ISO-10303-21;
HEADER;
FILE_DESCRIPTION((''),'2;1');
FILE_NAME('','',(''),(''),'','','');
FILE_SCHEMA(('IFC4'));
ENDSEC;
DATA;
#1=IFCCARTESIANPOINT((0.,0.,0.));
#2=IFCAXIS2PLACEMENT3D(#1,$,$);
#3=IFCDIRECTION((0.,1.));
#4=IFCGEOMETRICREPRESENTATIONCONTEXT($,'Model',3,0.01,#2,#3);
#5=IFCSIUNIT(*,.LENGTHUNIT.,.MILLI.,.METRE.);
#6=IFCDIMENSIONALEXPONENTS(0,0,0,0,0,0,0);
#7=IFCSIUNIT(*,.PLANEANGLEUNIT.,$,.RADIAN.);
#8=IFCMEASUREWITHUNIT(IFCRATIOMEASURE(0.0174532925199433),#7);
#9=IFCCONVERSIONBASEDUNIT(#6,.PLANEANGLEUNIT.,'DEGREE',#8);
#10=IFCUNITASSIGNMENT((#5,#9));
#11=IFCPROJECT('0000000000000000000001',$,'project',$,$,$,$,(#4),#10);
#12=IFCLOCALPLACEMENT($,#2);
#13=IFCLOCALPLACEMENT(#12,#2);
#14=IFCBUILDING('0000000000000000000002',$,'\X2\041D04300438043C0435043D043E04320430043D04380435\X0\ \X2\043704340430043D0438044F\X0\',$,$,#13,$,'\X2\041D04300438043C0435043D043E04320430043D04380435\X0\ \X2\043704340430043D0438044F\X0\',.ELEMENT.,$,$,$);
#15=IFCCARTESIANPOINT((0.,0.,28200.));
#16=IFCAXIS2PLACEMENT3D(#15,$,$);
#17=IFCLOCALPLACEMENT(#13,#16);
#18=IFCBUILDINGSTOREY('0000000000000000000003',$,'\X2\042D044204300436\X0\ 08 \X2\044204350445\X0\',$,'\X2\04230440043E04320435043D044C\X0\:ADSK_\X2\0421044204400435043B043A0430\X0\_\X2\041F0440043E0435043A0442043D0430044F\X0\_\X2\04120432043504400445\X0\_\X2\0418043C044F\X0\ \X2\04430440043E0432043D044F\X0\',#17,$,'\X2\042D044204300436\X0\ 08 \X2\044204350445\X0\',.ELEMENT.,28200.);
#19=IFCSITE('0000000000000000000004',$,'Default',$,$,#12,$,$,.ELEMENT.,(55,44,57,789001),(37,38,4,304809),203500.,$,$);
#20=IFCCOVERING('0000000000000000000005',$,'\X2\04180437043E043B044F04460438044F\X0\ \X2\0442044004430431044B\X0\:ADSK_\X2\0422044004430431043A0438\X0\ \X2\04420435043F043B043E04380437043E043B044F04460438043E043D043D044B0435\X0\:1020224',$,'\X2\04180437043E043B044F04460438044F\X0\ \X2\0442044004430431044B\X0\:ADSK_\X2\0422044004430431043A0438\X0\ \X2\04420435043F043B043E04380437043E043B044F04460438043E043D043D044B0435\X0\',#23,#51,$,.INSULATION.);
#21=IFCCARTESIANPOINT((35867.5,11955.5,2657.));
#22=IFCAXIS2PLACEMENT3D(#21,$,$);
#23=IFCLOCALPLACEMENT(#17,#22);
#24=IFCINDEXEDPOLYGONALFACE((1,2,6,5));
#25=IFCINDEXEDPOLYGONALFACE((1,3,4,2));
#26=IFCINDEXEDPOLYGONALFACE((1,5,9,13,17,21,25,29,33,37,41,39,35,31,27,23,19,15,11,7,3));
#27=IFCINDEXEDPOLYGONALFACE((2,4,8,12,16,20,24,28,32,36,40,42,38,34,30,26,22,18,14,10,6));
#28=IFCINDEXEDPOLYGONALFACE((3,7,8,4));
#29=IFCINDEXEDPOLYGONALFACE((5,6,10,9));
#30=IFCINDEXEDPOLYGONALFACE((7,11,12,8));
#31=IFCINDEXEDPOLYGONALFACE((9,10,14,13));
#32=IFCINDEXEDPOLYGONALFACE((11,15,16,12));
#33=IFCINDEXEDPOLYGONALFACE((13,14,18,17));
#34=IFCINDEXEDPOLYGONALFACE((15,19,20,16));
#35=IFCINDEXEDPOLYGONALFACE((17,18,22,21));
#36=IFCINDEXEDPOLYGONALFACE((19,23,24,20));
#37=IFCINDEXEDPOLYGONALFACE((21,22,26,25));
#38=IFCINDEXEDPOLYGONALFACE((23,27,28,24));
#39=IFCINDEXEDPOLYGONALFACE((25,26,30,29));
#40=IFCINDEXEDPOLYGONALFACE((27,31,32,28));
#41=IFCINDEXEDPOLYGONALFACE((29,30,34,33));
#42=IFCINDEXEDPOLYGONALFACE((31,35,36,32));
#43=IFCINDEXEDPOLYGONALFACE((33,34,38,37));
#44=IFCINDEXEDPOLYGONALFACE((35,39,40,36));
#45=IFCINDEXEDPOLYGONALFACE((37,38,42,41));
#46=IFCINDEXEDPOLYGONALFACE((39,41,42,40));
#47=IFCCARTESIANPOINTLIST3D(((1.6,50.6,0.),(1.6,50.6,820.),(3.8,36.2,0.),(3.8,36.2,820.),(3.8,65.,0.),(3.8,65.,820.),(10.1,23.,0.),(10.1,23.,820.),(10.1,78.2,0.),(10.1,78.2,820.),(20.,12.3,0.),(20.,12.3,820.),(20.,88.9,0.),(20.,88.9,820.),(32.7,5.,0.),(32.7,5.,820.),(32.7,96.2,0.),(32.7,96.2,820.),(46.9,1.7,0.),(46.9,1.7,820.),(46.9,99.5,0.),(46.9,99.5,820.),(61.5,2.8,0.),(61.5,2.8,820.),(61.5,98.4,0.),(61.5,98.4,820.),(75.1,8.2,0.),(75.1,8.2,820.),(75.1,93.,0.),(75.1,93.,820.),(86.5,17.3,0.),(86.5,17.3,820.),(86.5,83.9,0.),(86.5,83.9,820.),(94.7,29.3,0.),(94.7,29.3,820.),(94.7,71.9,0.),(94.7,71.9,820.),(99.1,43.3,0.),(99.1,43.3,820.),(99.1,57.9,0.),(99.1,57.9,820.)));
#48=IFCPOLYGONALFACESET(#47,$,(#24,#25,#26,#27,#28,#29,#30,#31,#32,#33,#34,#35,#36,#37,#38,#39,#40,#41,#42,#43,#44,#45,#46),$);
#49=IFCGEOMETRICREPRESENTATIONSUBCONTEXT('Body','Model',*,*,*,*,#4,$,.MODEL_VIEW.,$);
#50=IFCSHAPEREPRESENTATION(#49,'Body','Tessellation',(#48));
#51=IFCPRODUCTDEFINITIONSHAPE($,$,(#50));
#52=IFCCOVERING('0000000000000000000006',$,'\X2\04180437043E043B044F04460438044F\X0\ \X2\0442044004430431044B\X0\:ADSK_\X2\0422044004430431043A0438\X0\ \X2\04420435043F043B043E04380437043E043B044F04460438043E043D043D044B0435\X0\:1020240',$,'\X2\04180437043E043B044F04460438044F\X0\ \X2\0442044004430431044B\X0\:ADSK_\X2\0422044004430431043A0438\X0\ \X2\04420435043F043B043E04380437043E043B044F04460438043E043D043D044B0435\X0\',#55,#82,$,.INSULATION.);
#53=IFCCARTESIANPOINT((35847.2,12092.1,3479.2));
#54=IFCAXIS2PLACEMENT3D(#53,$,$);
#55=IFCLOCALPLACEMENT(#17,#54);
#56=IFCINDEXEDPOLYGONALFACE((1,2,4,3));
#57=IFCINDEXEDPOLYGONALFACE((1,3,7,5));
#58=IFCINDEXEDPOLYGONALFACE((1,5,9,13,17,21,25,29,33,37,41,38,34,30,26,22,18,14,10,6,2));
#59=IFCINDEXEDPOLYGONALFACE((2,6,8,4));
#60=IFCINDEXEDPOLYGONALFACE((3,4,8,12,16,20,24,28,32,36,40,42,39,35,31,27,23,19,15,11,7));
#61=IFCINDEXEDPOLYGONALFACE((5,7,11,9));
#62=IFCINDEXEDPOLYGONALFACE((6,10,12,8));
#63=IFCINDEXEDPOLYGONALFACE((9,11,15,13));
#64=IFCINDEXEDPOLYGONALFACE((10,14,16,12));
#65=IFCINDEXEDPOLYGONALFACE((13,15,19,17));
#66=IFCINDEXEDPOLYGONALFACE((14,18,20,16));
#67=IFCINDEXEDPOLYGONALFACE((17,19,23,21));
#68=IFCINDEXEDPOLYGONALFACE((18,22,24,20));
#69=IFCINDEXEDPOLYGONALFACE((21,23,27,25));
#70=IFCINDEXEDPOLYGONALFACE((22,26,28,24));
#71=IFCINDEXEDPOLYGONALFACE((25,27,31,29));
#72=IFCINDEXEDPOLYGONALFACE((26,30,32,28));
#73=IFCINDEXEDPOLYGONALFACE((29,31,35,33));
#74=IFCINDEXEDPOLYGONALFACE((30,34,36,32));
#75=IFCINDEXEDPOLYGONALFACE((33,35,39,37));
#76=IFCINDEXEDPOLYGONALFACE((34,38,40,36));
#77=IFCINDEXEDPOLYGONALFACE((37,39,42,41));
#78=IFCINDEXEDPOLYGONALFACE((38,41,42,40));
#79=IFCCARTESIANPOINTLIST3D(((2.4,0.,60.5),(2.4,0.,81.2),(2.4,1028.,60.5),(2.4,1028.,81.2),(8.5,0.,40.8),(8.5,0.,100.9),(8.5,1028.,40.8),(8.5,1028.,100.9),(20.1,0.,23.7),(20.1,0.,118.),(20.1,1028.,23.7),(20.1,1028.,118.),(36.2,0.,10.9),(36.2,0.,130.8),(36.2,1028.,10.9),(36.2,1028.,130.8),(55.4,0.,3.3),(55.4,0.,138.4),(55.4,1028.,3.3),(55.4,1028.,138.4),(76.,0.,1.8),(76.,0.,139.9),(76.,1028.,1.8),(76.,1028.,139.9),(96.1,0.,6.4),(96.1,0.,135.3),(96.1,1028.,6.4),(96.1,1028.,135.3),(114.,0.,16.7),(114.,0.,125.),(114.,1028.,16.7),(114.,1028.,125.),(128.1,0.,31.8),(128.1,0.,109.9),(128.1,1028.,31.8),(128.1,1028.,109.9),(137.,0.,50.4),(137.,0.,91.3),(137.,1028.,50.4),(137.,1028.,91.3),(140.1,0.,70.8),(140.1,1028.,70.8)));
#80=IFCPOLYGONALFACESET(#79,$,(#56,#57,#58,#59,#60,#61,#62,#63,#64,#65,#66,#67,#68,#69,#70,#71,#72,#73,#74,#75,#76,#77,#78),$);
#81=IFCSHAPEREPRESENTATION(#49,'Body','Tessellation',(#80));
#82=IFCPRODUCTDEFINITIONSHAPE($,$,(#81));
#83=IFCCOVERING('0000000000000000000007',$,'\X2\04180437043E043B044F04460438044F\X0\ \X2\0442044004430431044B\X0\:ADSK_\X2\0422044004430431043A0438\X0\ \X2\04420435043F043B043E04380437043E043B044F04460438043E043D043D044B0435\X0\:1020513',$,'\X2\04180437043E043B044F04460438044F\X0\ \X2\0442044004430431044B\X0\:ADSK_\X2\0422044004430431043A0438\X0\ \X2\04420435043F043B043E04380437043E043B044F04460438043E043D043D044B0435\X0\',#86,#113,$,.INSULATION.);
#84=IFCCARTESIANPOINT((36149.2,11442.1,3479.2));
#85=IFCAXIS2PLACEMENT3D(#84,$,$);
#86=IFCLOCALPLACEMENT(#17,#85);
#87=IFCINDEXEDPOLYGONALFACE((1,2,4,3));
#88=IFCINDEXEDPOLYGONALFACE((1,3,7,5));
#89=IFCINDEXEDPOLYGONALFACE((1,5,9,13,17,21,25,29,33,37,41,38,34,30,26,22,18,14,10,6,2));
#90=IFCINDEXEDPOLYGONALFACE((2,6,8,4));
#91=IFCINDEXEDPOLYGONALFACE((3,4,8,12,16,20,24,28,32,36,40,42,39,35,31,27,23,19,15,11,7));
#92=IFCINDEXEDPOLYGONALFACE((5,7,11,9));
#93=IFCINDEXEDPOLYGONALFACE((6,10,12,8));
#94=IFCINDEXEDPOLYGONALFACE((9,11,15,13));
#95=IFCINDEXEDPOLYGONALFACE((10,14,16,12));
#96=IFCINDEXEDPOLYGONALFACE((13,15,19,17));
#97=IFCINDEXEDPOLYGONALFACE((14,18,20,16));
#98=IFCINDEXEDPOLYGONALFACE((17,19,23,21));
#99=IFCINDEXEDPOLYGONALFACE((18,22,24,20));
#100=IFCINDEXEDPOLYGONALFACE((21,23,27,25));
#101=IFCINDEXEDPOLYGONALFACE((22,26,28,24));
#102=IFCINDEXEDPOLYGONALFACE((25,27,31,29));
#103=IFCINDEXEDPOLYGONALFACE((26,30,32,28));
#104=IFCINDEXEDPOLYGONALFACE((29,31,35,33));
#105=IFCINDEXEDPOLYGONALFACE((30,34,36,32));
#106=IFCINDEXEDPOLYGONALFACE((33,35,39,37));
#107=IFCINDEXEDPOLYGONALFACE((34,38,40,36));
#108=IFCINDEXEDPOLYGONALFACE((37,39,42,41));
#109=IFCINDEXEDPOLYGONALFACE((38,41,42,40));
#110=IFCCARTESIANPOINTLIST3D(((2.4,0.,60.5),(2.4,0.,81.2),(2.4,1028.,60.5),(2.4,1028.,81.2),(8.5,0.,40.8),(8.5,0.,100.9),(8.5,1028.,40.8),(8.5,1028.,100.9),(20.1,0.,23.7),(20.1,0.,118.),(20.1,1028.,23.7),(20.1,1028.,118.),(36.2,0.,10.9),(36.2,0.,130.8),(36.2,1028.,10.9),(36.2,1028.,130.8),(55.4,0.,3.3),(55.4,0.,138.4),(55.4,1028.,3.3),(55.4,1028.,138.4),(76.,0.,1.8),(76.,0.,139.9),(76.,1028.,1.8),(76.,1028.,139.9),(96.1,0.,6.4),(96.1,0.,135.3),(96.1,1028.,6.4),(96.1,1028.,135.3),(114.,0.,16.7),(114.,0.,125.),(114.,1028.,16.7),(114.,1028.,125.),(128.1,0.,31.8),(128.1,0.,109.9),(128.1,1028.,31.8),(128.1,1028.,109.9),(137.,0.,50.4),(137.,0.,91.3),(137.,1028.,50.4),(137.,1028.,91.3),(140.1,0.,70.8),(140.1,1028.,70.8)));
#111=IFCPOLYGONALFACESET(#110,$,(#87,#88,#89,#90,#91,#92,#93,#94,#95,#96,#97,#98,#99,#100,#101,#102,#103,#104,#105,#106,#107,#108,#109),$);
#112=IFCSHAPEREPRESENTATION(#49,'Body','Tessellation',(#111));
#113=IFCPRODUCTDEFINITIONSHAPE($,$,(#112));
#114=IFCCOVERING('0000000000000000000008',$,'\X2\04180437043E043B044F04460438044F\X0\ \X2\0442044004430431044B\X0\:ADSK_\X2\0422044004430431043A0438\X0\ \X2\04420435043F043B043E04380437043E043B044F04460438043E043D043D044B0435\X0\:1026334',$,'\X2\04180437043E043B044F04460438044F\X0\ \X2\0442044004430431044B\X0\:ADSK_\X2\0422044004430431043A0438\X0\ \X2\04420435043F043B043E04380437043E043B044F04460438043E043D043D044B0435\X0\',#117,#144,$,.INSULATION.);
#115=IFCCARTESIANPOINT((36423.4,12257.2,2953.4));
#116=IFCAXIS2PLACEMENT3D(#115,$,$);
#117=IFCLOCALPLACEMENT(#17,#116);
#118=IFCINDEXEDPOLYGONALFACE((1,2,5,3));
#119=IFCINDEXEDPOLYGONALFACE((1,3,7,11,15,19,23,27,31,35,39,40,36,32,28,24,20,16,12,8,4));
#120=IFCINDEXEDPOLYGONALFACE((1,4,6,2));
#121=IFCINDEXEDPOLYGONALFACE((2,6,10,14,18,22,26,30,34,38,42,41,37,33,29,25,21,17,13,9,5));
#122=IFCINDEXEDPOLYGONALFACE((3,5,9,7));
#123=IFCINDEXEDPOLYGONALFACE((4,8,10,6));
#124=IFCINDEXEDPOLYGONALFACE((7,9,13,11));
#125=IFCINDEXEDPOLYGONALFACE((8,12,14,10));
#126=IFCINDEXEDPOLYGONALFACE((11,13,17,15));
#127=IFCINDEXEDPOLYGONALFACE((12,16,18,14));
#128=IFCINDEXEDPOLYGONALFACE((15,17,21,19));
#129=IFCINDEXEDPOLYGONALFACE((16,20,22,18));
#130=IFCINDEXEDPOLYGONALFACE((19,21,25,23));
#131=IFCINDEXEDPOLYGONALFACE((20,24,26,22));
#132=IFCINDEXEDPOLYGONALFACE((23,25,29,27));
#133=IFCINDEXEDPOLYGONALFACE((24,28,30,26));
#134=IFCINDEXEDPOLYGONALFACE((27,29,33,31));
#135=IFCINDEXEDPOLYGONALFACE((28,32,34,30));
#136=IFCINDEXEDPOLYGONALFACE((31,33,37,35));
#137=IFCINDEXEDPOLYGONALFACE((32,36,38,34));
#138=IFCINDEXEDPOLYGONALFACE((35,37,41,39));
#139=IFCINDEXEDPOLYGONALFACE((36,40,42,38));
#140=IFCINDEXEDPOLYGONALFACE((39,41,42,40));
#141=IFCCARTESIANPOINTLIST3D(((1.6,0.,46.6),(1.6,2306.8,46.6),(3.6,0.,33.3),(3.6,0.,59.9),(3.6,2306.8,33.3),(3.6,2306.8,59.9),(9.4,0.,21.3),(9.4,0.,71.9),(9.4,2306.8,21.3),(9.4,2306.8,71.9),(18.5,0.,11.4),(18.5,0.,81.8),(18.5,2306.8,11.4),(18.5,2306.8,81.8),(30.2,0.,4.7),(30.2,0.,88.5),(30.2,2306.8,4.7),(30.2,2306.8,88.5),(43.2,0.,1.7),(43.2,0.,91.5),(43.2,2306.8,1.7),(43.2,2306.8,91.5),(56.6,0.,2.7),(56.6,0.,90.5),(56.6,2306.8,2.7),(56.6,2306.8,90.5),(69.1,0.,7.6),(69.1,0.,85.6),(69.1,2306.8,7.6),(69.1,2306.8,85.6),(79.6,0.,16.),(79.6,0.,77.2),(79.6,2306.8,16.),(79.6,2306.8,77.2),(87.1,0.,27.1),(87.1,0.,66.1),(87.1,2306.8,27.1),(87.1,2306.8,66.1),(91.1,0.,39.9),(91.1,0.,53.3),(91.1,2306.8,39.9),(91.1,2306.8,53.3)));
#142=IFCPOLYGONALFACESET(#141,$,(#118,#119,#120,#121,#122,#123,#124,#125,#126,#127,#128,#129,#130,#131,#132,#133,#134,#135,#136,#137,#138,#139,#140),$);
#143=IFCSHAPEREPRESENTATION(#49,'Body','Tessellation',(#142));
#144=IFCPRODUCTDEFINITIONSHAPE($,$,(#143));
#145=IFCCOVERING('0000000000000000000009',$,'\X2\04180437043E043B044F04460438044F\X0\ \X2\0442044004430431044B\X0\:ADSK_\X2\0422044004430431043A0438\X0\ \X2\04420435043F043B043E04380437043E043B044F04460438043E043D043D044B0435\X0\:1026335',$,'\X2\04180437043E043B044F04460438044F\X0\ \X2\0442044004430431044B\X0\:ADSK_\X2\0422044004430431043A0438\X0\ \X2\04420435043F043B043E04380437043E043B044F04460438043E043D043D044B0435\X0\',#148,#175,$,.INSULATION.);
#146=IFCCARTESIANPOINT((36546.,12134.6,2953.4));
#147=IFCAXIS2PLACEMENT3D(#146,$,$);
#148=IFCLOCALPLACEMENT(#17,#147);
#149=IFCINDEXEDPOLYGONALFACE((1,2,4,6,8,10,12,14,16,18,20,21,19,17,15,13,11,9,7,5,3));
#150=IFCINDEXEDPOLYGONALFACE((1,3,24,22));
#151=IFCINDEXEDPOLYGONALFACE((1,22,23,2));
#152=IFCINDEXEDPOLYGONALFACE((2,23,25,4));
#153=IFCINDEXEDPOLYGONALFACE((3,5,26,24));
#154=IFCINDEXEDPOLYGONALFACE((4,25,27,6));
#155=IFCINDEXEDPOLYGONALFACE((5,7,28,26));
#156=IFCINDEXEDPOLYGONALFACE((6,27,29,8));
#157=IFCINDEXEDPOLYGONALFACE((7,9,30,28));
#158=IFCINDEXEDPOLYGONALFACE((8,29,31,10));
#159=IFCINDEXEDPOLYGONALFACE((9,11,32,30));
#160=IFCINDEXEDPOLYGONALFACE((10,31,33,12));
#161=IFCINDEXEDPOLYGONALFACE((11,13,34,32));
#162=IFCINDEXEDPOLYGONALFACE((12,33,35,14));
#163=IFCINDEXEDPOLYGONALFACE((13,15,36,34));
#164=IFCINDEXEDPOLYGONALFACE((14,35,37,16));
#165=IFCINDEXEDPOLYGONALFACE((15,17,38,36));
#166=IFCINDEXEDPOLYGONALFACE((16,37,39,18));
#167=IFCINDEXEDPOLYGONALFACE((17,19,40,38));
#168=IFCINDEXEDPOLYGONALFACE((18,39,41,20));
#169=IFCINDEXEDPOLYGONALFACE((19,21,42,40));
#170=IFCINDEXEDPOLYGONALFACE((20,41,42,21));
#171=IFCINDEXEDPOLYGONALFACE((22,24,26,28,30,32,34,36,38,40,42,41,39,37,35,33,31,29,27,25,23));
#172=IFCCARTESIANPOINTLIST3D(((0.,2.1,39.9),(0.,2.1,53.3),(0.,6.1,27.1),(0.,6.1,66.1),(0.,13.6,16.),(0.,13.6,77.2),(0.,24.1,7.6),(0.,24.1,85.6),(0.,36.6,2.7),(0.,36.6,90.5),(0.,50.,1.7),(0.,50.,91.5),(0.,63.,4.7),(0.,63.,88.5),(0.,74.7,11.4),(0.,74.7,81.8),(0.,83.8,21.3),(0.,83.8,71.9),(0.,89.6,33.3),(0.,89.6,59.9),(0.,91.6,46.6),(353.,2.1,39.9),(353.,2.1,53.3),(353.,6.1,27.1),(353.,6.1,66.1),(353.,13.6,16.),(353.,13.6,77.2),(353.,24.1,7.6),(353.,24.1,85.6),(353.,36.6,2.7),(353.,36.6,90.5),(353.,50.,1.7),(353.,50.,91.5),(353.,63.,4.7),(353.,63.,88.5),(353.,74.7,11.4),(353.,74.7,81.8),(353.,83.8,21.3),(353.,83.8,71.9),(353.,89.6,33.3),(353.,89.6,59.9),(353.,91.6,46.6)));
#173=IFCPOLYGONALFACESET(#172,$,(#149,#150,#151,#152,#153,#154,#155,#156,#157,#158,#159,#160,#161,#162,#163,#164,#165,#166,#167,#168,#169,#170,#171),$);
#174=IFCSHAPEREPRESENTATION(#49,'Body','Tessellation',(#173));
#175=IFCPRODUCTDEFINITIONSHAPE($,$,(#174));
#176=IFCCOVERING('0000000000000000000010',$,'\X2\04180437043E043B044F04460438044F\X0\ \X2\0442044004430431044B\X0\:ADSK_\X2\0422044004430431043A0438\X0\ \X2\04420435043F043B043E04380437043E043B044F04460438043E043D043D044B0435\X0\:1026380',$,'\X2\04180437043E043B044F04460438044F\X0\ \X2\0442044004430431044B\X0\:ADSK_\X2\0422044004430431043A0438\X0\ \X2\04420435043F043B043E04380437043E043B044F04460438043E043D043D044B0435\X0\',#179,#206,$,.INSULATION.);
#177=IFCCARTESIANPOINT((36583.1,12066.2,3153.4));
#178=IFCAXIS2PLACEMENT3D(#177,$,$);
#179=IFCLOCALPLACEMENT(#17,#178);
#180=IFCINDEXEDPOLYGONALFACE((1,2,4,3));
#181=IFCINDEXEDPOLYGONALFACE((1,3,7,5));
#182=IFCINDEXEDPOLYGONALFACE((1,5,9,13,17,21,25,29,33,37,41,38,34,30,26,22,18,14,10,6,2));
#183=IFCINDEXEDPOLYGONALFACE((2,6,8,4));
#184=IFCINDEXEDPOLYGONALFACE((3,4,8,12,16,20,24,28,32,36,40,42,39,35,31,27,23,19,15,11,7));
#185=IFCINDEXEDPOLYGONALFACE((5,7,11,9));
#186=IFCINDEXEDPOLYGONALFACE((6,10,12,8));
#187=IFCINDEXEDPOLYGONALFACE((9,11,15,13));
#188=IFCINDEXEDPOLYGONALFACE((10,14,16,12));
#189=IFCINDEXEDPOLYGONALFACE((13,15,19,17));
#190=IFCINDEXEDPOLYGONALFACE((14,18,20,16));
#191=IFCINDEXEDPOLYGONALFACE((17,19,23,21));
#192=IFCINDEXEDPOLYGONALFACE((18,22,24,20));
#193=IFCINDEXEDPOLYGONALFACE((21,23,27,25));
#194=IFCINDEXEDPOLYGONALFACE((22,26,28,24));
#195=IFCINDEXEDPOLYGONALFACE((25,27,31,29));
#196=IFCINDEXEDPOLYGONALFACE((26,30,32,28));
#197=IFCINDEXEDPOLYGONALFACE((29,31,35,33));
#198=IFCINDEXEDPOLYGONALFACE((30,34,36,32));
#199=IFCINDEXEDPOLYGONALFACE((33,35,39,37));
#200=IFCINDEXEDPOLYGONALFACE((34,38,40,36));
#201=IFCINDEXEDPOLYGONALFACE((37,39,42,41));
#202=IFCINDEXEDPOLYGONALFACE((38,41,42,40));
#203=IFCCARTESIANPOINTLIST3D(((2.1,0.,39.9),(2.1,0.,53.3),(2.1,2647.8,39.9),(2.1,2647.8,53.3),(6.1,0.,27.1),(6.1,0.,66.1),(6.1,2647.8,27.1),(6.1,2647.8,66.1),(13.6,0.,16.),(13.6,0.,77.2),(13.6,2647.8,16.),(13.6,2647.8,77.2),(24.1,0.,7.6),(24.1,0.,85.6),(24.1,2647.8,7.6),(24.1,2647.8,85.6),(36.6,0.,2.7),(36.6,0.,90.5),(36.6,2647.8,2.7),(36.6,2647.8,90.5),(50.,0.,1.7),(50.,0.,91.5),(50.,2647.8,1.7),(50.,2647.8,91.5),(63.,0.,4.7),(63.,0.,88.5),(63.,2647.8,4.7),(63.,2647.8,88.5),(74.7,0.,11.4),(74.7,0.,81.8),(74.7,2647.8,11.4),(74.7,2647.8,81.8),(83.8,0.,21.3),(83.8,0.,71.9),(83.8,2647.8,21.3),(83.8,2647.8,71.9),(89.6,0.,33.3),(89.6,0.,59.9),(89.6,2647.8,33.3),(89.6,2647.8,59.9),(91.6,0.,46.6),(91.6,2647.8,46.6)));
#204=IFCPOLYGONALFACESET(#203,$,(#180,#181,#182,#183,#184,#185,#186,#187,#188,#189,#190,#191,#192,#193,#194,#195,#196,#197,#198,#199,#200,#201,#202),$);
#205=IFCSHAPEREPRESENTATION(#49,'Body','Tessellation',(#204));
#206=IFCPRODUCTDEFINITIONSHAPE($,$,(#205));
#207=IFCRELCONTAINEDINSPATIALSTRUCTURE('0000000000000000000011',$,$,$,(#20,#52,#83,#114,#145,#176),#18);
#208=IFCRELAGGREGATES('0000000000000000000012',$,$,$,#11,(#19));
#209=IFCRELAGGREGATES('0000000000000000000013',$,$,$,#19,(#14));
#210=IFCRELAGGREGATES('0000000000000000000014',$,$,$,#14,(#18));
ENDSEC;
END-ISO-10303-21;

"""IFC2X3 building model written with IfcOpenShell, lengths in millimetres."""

from ifc_helpers import new_model, entity, si_unit, converted_unit, direction, frame, origin, origin_2d_with_axis, place, context, subcontext, project, spatial, circle, extrude, element, save


model = new_model("IFC2X3")

# Units and contexts
model_context = context("Model", 3, precision=0.01, world=origin(), true_north=direction((0.0, 1.0)))
body_context = subcontext(model_context, "Body", "Model", "MODEL_VIEW")
ifc_project = project(units=[si_unit("LENGTHUNIT", "METRE", prefix="MILLI"), converted_unit("PLANEANGLEUNIT", "DEGREE", entity("IfcRatioMeasure", 0.0174532925199433), si_unit("PLANEANGLEUNIT", "RADIAN"), dimensions=[0, 0, 0, 0, 0, 0, 0])], contexts=[model_context])

# Site, building, storey
site_placement = place(None, origin())
site = spatial("IfcSite", under=ifc_project, at=site_placement, Name="Default", CompositionType="ELEMENT", RefLatitude=(55, 44, 57, 789001), RefLongitude=(37, 38, 4, 304809), RefElevation=203500.0)
building_placement = place(site_placement, origin())
building = spatial("IfcBuilding", under=site, at=building_placement, Name="Наименование здания", LongName="Наименование здания", CompositionType="ELEMENT")
storey_placement = place(building_placement, frame((0.0, 0.0, 28200.0)))
storey = spatial("IfcBuildingStorey", under=building, at=storey_placement, Name="Этаж 08 тех", ObjectType="Уровень:ADSK_Стрелка_Проектная_Вверх_Имя уровня", LongName="Этаж 08 тех", CompositionType="ELEMENT", Elevation=28200.0)

# Coverings
covering_1_placement = place(storey_placement, frame((35867.5, 11955.5, 2657.0)))
element("IfcCovering", 1, at=covering_1_placement, inside=storey, Name="Изоляция трубы:ADSK_Трубки теплоизоляционные:1020224", ObjectType="Изоляция трубы:ADSK_Трубки теплоизоляционные", PredefinedType="INSULATION", context=body_context, shape_type="SweptSolid", body=[
    extrude(circle(Radius=49.0, at=origin_2d_with_axis()), frame((50.6, 50.6, 0.0), z_axis=(0.0, 0.0, 1.0), x_axis=(-1.0, 0.0, 0.0)), (0.0, 0.0, 1.0), 820.0),
])
covering_2_placement = place(storey_placement, frame((35847.2, 12092.1, 3479.2)))
element("IfcCovering", 2, at=covering_2_placement, inside=storey, Name="Изоляция трубы:ADSK_Трубки теплоизоляционные:1020240", ObjectType="Изоляция трубы:ADSK_Трубки теплоизоляционные", PredefinedType="INSULATION", context=body_context, shape_type="SweptSolid", body=[
    extrude(circle(Radius=69.2, at=origin_2d_with_axis()), frame((70.8, 0.0, 70.8), z_axis=(0.0, 1.0, 0.0), x_axis=(1.0, 0.0, 0.0)), (0.0, 0.0, 1.0), 1028.0),
])
covering_3_placement = place(storey_placement, frame((36149.2, 11442.1, 3479.2)))
element("IfcCovering", 3, at=covering_3_placement, inside=storey, Name="Изоляция трубы:ADSK_Трубки теплоизоляционные:1020513", ObjectType="Изоляция трубы:ADSK_Трубки теплоизоляционные", PredefinedType="INSULATION", context=body_context, shape_type="SweptSolid", body=[
    extrude(circle(Radius=69.2, at=origin_2d_with_axis()), frame((70.8, 0.0, 70.8), z_axis=(0.0, 1.0, 0.0), x_axis=(1.0, 0.0, 0.0)), (0.0, 0.0, 1.0), 1028.0),
])
covering_4_placement = place(storey_placement, frame((36423.4, 12257.2, 2953.4)))
element("IfcCovering", 4, at=covering_4_placement, inside=storey, Name="Изоляция трубы:ADSK_Трубки теплоизоляционные:1026334", ObjectType="Изоляция трубы:ADSK_Трубки теплоизоляционные", PredefinedType="INSULATION", context=body_context, shape_type="SweptSolid", body=[
    extrude(circle(Radius=45.0, at=origin_2d_with_axis()), frame((46.6, 0.0, 46.6), z_axis=(0.0, 1.0, 0.0), x_axis=(-1.0, 0.0, 0.0)), (0.0, 0.0, 1.0), 2306.8),
])
covering_5_placement = place(storey_placement, frame((36546.0, 12134.6, 2953.4)))
element("IfcCovering", 5, at=covering_5_placement, inside=storey, Name="Изоляция трубы:ADSK_Трубки теплоизоляционные:1026335", ObjectType="Изоляция трубы:ADSK_Трубки теплоизоляционные", PredefinedType="INSULATION", context=body_context, shape_type="SweptSolid", body=[
    extrude(circle(Radius=45.0, at=origin_2d_with_axis()), frame((0.0, 46.6, 46.6), z_axis=(1.0, 0.0, 0.0), x_axis=(0.0, 1.0, 0.0)), (0.0, 0.0, 1.0), 353.0),
])
covering_6_placement = place(storey_placement, frame((36583.1, 12066.2, 3153.4)))
element("IfcCovering", 6, at=covering_6_placement, inside=storey, Name="Изоляция трубы:ADSK_Трубки теплоизоляционные:1026380", ObjectType="Изоляция трубы:ADSK_Трубки теплоизоляционные", PredefinedType="INSULATION", context=body_context, shape_type="SweptSolid", body=[
    extrude(circle(Radius=45.0, at=origin_2d_with_axis()), frame((46.6, 0.0, 46.6), z_axis=(0.0, 1.0, 0.0), x_axis=(1.0, 0.0, 0.0)), (0.0, 0.0, 1.0), 2647.8),
])

save(model, "model.ifc")
